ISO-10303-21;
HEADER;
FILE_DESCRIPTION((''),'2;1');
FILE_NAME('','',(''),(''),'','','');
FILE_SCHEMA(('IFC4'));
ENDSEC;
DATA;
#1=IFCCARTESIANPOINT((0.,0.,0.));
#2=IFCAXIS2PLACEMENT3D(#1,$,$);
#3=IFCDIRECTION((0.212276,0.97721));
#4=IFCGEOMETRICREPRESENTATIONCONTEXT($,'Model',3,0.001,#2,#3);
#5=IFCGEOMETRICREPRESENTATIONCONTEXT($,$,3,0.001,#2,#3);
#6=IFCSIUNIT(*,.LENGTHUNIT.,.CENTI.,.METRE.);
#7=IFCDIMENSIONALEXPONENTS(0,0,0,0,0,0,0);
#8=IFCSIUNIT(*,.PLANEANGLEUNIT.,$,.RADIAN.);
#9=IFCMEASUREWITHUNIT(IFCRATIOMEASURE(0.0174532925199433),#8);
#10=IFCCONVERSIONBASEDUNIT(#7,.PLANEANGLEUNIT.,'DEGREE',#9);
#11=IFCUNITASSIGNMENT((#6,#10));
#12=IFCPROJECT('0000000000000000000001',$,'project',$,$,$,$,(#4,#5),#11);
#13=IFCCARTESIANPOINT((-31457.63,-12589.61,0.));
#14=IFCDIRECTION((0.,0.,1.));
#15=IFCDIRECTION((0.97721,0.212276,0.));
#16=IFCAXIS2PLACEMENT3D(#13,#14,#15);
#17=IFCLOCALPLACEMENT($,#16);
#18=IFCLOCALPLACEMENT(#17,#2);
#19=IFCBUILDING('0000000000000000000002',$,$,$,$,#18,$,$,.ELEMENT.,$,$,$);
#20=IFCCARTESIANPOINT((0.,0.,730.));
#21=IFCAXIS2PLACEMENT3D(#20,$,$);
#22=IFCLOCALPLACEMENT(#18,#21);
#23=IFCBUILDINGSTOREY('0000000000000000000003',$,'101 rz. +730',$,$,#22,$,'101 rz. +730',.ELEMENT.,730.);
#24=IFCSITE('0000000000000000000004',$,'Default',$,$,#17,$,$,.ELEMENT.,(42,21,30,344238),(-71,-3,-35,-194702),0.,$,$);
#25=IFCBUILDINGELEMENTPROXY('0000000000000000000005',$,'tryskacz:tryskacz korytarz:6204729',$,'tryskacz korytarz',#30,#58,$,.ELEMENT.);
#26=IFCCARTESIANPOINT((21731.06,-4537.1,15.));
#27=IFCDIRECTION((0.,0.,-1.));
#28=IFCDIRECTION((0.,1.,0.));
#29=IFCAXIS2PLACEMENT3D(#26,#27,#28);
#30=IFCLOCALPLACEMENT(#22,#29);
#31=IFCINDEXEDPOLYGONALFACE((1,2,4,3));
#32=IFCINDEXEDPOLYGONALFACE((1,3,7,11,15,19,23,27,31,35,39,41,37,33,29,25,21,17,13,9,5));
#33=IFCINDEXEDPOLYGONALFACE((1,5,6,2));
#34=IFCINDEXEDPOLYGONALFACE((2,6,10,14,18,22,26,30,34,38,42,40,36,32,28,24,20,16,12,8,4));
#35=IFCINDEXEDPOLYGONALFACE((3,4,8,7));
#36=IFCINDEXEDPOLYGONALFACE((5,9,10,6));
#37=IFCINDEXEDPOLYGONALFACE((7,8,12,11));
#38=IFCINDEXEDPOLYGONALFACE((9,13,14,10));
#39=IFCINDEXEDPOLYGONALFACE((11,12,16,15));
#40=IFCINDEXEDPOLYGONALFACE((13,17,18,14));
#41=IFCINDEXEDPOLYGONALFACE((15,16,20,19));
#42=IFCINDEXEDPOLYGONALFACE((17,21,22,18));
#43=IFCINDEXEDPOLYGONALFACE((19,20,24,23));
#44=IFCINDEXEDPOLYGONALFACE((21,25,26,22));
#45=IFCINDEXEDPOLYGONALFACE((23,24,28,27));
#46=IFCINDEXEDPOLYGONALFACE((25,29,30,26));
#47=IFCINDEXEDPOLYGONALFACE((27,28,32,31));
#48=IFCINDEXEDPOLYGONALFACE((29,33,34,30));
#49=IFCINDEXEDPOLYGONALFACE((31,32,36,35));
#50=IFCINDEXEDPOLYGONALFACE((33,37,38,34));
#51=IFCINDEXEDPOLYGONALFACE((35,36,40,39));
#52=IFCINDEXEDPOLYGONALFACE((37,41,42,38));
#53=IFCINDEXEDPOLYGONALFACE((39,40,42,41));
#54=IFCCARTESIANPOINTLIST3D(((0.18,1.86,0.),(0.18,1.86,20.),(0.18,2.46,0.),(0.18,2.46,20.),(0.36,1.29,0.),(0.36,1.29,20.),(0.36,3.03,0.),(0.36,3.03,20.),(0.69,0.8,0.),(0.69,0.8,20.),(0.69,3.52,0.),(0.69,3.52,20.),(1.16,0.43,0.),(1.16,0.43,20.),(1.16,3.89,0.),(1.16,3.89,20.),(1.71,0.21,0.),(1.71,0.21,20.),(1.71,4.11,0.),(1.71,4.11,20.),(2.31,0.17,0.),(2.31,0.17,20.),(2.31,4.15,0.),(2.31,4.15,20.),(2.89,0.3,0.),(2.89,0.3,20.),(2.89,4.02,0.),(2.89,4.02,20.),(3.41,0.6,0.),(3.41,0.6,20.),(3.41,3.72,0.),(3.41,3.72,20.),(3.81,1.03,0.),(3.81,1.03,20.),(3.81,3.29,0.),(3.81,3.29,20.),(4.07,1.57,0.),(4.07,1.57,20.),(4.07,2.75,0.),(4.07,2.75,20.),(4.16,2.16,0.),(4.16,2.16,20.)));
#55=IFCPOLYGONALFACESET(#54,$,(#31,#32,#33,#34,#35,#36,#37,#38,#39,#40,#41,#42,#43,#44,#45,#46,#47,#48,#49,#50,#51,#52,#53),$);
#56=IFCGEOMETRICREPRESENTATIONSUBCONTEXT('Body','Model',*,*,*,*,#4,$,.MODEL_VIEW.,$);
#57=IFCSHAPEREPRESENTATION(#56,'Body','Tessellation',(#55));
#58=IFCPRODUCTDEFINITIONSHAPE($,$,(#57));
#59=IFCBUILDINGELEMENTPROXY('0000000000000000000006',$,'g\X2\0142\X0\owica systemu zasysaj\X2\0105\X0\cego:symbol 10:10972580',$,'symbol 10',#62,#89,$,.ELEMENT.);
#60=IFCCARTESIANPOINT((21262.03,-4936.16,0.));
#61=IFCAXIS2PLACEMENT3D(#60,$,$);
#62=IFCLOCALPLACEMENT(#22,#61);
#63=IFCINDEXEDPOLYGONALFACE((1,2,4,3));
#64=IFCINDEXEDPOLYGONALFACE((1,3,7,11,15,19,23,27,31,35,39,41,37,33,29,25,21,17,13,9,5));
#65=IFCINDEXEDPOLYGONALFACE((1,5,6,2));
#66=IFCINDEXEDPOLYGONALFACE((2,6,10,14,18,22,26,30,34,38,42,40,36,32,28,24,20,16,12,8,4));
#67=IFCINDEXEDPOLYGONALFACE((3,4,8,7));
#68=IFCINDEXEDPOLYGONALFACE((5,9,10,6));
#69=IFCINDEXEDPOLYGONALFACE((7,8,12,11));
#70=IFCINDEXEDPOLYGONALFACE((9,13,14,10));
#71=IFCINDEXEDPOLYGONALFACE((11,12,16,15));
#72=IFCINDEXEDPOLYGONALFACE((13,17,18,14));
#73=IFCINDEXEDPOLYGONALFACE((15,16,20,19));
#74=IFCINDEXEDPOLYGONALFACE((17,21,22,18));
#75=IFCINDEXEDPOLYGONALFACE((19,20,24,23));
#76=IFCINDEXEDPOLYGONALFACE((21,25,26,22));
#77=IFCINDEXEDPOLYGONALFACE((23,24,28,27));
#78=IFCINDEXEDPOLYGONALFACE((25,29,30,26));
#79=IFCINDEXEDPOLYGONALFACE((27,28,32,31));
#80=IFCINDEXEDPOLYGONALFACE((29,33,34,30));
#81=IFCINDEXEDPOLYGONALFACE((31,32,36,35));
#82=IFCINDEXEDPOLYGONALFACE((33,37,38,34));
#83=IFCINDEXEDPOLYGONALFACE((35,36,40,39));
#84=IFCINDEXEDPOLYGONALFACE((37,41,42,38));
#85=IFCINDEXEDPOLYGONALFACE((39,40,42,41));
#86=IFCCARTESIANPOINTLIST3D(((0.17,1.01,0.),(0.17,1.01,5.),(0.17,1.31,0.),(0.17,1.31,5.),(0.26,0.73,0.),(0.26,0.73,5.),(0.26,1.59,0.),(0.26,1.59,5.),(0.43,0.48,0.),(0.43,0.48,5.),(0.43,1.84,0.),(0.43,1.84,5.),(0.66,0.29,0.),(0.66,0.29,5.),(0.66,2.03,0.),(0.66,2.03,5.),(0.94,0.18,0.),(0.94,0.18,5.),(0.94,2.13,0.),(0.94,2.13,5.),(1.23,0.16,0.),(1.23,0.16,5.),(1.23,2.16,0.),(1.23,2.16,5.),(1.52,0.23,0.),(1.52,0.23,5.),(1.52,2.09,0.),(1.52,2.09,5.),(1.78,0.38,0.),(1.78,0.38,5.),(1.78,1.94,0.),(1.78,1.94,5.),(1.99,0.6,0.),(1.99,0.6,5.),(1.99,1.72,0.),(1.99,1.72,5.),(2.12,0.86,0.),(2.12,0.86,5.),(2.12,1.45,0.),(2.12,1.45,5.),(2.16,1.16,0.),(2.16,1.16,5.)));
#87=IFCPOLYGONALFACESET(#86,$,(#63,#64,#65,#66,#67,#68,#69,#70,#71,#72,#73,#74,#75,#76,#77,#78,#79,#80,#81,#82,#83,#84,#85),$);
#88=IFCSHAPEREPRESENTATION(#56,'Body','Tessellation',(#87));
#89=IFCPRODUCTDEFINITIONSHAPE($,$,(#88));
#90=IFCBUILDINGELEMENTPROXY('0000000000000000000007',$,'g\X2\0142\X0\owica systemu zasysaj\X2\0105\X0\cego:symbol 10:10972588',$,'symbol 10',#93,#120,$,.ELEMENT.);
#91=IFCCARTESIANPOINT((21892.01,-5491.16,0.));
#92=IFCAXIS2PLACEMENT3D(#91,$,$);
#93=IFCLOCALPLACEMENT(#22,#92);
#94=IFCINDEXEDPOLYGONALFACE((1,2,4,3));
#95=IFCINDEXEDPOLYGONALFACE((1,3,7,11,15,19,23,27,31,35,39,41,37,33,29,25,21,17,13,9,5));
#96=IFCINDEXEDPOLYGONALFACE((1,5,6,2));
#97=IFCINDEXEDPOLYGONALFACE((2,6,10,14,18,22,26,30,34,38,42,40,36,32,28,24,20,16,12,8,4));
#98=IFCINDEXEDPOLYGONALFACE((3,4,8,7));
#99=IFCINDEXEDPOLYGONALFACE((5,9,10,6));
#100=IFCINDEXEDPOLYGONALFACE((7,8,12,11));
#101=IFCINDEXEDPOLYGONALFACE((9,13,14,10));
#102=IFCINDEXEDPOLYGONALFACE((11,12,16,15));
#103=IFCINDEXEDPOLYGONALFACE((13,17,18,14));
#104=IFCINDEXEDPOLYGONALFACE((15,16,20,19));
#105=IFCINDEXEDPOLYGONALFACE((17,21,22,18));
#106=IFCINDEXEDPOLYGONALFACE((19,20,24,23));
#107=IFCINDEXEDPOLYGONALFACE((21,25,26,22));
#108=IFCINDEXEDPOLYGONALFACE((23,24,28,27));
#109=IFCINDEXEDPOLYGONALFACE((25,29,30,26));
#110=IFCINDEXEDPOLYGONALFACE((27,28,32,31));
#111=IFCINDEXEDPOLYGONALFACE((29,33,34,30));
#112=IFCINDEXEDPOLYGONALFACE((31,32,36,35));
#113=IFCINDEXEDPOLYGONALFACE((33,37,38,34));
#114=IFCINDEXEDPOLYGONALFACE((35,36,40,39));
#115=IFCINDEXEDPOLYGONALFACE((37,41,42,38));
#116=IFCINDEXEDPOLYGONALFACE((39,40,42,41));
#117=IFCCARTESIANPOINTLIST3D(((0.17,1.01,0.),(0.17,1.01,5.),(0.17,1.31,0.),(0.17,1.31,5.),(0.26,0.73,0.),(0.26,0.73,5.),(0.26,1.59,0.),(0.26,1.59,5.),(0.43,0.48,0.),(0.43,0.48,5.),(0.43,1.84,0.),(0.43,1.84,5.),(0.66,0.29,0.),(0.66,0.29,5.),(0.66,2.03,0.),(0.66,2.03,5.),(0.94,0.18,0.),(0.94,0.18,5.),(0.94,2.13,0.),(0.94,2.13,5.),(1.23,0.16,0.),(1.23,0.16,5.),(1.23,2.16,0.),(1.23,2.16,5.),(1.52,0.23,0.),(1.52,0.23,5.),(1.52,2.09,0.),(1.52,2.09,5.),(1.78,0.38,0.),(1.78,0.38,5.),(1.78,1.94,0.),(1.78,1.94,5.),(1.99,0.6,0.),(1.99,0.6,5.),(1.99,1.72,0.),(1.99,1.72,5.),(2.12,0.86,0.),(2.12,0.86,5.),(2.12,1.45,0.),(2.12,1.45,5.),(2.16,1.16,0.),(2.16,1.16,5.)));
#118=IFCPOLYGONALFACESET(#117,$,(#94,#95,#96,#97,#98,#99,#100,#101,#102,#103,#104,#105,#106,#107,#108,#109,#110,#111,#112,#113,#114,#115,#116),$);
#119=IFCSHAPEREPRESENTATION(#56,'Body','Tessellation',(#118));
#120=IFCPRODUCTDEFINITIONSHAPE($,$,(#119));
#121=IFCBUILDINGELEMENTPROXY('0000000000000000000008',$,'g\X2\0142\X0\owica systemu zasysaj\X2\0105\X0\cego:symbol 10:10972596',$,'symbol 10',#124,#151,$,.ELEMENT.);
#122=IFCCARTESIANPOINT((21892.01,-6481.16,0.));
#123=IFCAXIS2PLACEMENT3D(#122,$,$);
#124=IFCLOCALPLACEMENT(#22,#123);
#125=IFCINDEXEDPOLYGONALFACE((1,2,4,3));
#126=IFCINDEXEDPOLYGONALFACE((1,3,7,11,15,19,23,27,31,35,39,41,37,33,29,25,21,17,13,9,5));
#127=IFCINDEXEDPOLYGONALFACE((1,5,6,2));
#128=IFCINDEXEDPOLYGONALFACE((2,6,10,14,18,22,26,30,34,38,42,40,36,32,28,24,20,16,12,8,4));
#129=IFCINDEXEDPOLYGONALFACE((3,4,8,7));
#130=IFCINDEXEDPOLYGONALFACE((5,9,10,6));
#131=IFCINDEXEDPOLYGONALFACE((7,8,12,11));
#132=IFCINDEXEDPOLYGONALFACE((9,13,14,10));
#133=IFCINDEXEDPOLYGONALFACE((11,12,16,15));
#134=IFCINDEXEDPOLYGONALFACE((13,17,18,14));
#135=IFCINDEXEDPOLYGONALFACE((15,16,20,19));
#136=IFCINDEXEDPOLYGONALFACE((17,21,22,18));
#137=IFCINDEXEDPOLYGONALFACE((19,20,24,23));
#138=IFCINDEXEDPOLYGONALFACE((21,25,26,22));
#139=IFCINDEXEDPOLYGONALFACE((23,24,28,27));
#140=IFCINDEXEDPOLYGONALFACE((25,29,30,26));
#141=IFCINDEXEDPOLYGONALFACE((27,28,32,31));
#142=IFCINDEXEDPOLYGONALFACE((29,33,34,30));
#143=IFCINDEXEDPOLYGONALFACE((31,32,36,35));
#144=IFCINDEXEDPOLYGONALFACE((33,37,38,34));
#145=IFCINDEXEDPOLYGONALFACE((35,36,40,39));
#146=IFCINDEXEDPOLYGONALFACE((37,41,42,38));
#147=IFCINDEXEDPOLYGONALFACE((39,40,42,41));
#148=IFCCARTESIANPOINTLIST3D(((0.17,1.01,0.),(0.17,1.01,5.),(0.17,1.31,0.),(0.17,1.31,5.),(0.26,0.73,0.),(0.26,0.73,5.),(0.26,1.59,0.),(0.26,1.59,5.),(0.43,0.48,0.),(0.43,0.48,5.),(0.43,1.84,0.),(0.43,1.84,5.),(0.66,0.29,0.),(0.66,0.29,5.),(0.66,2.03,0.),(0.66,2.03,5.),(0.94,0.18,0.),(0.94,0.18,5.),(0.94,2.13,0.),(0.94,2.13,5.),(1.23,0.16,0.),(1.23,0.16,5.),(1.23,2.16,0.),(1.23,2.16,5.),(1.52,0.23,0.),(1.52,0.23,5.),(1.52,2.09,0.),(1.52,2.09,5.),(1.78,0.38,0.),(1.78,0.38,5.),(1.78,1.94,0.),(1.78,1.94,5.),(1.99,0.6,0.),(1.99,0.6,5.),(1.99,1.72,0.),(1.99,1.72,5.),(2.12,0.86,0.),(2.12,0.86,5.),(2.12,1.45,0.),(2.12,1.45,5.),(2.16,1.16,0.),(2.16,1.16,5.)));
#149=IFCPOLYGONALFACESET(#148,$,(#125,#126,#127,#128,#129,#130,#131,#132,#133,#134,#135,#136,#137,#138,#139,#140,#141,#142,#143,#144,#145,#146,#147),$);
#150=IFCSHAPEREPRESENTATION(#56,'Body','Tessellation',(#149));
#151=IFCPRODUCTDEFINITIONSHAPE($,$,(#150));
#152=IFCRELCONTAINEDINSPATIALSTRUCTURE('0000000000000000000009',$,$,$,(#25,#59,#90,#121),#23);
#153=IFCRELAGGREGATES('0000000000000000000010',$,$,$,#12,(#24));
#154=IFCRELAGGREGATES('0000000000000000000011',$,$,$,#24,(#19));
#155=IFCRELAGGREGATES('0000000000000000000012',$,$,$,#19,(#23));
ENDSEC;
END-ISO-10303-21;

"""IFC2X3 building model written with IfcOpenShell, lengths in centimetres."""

from ifc_helpers import new_model, entity, si_unit, converted_unit, direction, frame, frame_2d, origin, place, context, subcontext, project, spatial, circle, extrude, source, transform, mapped, element, save


model = new_model("IFC2X3")

# Units and contexts
model_context = context("Model", 3, precision=0.001, world=origin(), true_north=direction((0.212276, 0.97721)))
context_of_model = context(None, 3, precision=0.001, world=origin(), true_north=direction((0.212276, 0.97721)))
body_context = subcontext(model_context, "Body", "Model", "MODEL_VIEW")
ifc_project = project(units=[si_unit("LENGTHUNIT", "METRE", prefix="CENTI"), converted_unit("PLANEANGLEUNIT", "DEGREE", entity("IfcRatioMeasure", 0.0174532925199433), si_unit("PLANEANGLEUNIT", "RADIAN"), dimensions=[0, 0, 0, 0, 0, 0, 0])], contexts=[model_context, context_of_model])

# Site, building, storey
site_placement = place(None, frame((-31457.63, -12589.61, 0.0), z_axis=(0.0, 0.0, 1.0), x_axis=(0.97721, 0.212276, 0.0)))
site = spatial("IfcSite", under=ifc_project, at=site_placement, Name="Default", CompositionType="ELEMENT", RefLatitude=(42, 21, 30, 344238), RefLongitude=(-71, -3, -35, -194702), RefElevation=0.0)
building_placement = place(site_placement, origin())
building = spatial("IfcBuilding", under=site, at=building_placement, CompositionType="ELEMENT")
storey_placement = place(building_placement, frame((0.0, 0.0, 730.0)))
storey = spatial("IfcBuildingStorey", under=building, at=storey_placement, Name="101 rz. +730", LongName="101 rz. +730", CompositionType="ELEMENT", Elevation=730.0)

# Building element proxies
shared_shape_1 = source(origin(), body_context, "Body", "SweptSolid", [
    extrude(circle(Radius=2.0, at=frame_2d((0.0, 0.0), x_axis=(1.0, 0.0))), frame((2.16, 2.16, 0.0)), (0.0, 0.0, 1.0), 20.0),
])
for number, where, z_axis, x_axis, name in (
    (1, (21731.06, -4537.1, 15.0), (0.0, 0.0, -1.0), (0.0, 1.0, 0.0), "tryskacz:tryskacz korytarz:6204729"),
):
    element("IfcBuildingElementProxy", number, at=place(storey_placement, frame(where, z_axis=z_axis, x_axis=x_axis)), inside=storey, Name=name, ObjectType="tryskacz korytarz", CompositionType="ELEMENT", context=body_context, shape_type="MappedRepresentation", body=[
        mapped(shared_shape_1, transform((0.0, 0.0, 0.0), scale=1.0)),
    ])
shared_shape_2 = source(origin(), body_context, "Body", "SweptSolid", [
    extrude(circle(Radius=1.0, at=frame_2d((0.0, 0.0), x_axis=(1.0, 0.0))), frame((1.16, 1.16, 0.0)), (0.0, 0.0, 1.0), 5.0),
])
for number, where, name in (
    (2, (21262.03, -4936.16, 0.0), "głowica systemu zasysającego:symbol 10:10972580"),
    (3, (21892.01, -5491.16, 0.0), "głowica systemu zasysającego:symbol 10:10972588"),
    (4, (21892.01, -6481.16, 0.0), "głowica systemu zasysającego:symbol 10:10972596"),
):
    element("IfcBuildingElementProxy", number, at=place(storey_placement, frame(where)), inside=storey, Name=name, ObjectType="symbol 10", CompositionType="ELEMENT", context=body_context, shape_type="MappedRepresentation", body=[
        mapped(shared_shape_2, transform((0.0, 0.0, 0.0), scale=1.0)),
    ])

save(model, "model.ifc")
